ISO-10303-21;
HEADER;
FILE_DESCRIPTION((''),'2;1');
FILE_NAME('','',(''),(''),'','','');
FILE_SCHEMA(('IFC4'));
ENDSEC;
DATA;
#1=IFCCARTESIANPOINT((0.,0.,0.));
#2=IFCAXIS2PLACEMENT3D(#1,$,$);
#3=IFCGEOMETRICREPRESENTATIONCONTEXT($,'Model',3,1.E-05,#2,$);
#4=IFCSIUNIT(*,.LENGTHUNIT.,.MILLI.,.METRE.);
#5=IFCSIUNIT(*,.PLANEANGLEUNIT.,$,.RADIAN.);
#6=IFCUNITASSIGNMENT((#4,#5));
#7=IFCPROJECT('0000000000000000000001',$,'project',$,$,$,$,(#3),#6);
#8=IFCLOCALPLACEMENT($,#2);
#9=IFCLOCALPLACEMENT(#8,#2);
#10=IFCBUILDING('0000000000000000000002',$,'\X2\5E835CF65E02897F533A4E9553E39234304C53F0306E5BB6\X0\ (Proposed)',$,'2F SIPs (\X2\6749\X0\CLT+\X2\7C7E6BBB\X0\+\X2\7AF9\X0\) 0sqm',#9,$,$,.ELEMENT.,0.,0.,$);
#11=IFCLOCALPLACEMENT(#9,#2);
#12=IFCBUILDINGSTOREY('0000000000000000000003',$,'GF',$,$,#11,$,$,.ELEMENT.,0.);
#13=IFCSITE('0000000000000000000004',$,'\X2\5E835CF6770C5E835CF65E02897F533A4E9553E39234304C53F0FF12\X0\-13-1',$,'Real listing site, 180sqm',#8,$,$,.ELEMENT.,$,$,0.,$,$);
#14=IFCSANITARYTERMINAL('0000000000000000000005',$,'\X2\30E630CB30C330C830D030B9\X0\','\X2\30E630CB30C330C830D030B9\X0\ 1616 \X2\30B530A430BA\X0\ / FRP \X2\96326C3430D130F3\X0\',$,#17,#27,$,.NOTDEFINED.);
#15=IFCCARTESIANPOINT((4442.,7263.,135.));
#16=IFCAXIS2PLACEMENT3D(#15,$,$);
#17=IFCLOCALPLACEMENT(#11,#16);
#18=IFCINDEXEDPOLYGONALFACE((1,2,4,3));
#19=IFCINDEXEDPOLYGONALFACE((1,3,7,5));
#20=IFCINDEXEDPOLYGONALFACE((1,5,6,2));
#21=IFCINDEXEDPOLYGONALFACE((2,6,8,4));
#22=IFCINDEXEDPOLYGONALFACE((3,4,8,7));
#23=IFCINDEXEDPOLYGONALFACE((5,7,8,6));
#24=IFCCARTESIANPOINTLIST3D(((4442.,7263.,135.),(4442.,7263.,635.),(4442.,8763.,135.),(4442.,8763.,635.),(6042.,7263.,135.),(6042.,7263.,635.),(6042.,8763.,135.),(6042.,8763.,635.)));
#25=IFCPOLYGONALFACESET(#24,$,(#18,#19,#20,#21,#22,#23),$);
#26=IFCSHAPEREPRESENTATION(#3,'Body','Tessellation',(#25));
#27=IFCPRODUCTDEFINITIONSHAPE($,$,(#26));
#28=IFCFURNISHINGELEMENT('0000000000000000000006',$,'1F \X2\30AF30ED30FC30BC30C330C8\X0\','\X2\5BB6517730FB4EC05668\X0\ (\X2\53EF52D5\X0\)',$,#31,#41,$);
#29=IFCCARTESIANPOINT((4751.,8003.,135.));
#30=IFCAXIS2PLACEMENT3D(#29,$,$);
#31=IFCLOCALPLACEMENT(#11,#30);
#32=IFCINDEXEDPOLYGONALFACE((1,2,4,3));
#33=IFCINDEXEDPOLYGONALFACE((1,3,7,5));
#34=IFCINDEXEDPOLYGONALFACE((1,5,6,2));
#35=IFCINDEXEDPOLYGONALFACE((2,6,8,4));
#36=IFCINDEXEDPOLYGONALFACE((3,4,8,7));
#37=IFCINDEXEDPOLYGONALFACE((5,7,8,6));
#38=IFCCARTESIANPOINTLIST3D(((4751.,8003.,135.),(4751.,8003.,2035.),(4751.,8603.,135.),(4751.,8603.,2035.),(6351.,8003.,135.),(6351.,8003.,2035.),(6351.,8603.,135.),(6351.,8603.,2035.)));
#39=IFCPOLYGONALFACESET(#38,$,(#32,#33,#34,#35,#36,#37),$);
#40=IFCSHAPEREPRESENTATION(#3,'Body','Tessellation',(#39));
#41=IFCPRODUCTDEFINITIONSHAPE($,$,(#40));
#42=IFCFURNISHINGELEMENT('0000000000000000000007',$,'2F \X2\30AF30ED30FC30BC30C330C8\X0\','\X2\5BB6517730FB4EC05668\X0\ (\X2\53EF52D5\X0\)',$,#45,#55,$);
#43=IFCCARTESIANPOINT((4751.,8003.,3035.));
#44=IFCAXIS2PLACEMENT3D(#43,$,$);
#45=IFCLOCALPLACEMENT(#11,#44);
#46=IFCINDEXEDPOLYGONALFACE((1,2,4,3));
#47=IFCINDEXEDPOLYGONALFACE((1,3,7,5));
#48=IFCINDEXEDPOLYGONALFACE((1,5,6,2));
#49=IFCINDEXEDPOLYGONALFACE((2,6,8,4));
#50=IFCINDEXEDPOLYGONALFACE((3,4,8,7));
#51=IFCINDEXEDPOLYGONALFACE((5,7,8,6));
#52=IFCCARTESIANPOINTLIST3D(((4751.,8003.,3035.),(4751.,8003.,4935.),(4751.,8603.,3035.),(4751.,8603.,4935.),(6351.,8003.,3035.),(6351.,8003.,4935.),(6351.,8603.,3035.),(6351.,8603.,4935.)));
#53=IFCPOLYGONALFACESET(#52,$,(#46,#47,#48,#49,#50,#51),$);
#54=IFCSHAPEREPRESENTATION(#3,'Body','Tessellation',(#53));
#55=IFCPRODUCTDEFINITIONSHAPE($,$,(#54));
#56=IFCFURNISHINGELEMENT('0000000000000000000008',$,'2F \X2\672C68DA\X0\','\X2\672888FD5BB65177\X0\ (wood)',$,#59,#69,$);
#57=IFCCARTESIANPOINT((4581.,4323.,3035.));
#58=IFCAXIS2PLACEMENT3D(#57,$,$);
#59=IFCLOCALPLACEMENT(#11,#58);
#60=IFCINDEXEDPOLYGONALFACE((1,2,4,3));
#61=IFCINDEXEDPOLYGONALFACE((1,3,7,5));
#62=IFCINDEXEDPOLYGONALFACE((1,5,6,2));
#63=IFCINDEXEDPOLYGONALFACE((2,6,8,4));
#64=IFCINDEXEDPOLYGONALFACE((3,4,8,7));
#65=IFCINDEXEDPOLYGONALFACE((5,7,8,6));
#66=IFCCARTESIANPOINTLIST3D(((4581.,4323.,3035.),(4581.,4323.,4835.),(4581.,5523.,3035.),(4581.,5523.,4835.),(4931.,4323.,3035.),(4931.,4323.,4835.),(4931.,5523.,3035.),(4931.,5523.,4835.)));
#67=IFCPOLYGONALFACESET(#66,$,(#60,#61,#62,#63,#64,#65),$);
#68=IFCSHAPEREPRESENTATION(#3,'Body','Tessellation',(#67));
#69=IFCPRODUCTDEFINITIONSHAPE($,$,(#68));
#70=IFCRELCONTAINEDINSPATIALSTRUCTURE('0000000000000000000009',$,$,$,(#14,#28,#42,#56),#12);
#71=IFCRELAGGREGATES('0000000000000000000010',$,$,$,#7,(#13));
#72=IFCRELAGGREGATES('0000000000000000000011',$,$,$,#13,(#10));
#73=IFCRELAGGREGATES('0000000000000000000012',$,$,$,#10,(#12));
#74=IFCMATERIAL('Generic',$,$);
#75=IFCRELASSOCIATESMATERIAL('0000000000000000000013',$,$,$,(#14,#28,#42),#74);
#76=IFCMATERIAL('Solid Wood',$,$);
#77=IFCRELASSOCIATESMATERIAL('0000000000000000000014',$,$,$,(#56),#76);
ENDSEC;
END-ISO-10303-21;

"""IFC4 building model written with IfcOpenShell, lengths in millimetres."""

from ifc_helpers import new_model, si_unit, frame, frame_2d, origin, place, context, project, spatial, rectangle, extrude, material, element, save


model = new_model("IFC4")

# Units and contexts
model_context = context("Model", 3, precision=1e-05, world=origin())
ifc_project = project(units=[si_unit("LENGTHUNIT", "METRE", prefix="MILLI"), si_unit("PLANEANGLEUNIT", "RADIAN")], contexts=[model_context])

# Site, building, storey
site_placement = place(None, origin())
site = spatial("IfcSite", under=ifc_project, at=site_placement, Name="広島県広島市西区井口鈴が台２-13-1", ObjectType="Real listing site, 180sqm", CompositionType="ELEMENT", RefElevation=0.0)
building_placement = place(site_placement, origin())
building = spatial("IfcBuilding", under=site, at=building_placement, Name="広島市西区井口鈴が台の家 (Proposed)", ObjectType="2F SIPs (杉CLT+籾殻+竹) 0sqm", CompositionType="ELEMENT", ElevationOfRefHeight=0.0, ElevationOfTerrain=0.0)
storey_placement = place(building_placement, origin())
storey = spatial("IfcBuildingStorey", under=building, at=storey_placement, Name="GF", CompositionType="ELEMENT", Elevation=0.0)

# Shared definitions
ifc_material_1 = material(Name="Solid Wood")

# Shared definitions
ifc_material_2 = material(Name="Generic")

# Sanitary terminal
sanitary_terminal_placement = place(storey_placement, frame((4442.0, 7263.0, 135.0)))
element("IfcSanitaryTerminal", 1, at=sanitary_terminal_placement, inside=storey, material=ifc_material_2, Name="ユニットバス", Description="ユニットバス 1616 サイズ / FRP 防水パン", PredefinedType="NOTDEFINED", context=model_context, shape_type="SweptSolid", body=[
    extrude(rectangle(XDim=1600.0, YDim=1500.0, at=frame_2d((800.0, 750.0))), frame((4442.0, 7263.0, 135.0)), (0.0, 0.0, 1.0), 500.0),
])

# Furnishing elements
furnishing_1_placement = place(storey_placement, frame((4751.0, 8003.0, 135.0)))
element("IfcFurnishingElement", 2, at=furnishing_1_placement, inside=storey, material=ifc_material_2, Name="1F クローゼット", Description="家具・什器 (可動)", context=model_context, shape_type="SweptSolid", body=[
    extrude(rectangle(XDim=1600.0, YDim=600.0, at=frame_2d((800.0, 300.0))), frame((4751.0, 8003.0, 135.0)), (0.0, 0.0, 1.0), 1900.0),
])
furnishing_2_placement = place(storey_placement, frame((4751.0, 8003.0, 3035.0)))
element("IfcFurnishingElement", 3, at=furnishing_2_placement, inside=storey, material=ifc_material_2, Name="2F クローゼット", Description="家具・什器 (可動)", context=model_context, shape_type="SweptSolid", body=[
    extrude(rectangle(XDim=1600.0, YDim=600.0, at=frame_2d((800.0, 300.0))), frame((4751.0, 8003.0, 3035.0)), (0.0, 0.0, 1.0), 1900.0),
])
furnishing_3_placement = place(storey_placement, frame((4581.0, 4323.0, 3035.0)))
element("IfcFurnishingElement", 4, at=furnishing_3_placement, inside=storey, material=ifc_material_1, Name="2F 本棚", Description="木製家具 (wood)", context=model_context, shape_type="SweptSolid", body=[
    extrude(rectangle(XDim=350.0, YDim=1200.0, at=frame_2d((175.0, 600.0))), frame((4581.0, 4323.0, 3035.0)), (0.0, 0.0, 1.0), 1800.0),
])

save(model, "model.ifc")
